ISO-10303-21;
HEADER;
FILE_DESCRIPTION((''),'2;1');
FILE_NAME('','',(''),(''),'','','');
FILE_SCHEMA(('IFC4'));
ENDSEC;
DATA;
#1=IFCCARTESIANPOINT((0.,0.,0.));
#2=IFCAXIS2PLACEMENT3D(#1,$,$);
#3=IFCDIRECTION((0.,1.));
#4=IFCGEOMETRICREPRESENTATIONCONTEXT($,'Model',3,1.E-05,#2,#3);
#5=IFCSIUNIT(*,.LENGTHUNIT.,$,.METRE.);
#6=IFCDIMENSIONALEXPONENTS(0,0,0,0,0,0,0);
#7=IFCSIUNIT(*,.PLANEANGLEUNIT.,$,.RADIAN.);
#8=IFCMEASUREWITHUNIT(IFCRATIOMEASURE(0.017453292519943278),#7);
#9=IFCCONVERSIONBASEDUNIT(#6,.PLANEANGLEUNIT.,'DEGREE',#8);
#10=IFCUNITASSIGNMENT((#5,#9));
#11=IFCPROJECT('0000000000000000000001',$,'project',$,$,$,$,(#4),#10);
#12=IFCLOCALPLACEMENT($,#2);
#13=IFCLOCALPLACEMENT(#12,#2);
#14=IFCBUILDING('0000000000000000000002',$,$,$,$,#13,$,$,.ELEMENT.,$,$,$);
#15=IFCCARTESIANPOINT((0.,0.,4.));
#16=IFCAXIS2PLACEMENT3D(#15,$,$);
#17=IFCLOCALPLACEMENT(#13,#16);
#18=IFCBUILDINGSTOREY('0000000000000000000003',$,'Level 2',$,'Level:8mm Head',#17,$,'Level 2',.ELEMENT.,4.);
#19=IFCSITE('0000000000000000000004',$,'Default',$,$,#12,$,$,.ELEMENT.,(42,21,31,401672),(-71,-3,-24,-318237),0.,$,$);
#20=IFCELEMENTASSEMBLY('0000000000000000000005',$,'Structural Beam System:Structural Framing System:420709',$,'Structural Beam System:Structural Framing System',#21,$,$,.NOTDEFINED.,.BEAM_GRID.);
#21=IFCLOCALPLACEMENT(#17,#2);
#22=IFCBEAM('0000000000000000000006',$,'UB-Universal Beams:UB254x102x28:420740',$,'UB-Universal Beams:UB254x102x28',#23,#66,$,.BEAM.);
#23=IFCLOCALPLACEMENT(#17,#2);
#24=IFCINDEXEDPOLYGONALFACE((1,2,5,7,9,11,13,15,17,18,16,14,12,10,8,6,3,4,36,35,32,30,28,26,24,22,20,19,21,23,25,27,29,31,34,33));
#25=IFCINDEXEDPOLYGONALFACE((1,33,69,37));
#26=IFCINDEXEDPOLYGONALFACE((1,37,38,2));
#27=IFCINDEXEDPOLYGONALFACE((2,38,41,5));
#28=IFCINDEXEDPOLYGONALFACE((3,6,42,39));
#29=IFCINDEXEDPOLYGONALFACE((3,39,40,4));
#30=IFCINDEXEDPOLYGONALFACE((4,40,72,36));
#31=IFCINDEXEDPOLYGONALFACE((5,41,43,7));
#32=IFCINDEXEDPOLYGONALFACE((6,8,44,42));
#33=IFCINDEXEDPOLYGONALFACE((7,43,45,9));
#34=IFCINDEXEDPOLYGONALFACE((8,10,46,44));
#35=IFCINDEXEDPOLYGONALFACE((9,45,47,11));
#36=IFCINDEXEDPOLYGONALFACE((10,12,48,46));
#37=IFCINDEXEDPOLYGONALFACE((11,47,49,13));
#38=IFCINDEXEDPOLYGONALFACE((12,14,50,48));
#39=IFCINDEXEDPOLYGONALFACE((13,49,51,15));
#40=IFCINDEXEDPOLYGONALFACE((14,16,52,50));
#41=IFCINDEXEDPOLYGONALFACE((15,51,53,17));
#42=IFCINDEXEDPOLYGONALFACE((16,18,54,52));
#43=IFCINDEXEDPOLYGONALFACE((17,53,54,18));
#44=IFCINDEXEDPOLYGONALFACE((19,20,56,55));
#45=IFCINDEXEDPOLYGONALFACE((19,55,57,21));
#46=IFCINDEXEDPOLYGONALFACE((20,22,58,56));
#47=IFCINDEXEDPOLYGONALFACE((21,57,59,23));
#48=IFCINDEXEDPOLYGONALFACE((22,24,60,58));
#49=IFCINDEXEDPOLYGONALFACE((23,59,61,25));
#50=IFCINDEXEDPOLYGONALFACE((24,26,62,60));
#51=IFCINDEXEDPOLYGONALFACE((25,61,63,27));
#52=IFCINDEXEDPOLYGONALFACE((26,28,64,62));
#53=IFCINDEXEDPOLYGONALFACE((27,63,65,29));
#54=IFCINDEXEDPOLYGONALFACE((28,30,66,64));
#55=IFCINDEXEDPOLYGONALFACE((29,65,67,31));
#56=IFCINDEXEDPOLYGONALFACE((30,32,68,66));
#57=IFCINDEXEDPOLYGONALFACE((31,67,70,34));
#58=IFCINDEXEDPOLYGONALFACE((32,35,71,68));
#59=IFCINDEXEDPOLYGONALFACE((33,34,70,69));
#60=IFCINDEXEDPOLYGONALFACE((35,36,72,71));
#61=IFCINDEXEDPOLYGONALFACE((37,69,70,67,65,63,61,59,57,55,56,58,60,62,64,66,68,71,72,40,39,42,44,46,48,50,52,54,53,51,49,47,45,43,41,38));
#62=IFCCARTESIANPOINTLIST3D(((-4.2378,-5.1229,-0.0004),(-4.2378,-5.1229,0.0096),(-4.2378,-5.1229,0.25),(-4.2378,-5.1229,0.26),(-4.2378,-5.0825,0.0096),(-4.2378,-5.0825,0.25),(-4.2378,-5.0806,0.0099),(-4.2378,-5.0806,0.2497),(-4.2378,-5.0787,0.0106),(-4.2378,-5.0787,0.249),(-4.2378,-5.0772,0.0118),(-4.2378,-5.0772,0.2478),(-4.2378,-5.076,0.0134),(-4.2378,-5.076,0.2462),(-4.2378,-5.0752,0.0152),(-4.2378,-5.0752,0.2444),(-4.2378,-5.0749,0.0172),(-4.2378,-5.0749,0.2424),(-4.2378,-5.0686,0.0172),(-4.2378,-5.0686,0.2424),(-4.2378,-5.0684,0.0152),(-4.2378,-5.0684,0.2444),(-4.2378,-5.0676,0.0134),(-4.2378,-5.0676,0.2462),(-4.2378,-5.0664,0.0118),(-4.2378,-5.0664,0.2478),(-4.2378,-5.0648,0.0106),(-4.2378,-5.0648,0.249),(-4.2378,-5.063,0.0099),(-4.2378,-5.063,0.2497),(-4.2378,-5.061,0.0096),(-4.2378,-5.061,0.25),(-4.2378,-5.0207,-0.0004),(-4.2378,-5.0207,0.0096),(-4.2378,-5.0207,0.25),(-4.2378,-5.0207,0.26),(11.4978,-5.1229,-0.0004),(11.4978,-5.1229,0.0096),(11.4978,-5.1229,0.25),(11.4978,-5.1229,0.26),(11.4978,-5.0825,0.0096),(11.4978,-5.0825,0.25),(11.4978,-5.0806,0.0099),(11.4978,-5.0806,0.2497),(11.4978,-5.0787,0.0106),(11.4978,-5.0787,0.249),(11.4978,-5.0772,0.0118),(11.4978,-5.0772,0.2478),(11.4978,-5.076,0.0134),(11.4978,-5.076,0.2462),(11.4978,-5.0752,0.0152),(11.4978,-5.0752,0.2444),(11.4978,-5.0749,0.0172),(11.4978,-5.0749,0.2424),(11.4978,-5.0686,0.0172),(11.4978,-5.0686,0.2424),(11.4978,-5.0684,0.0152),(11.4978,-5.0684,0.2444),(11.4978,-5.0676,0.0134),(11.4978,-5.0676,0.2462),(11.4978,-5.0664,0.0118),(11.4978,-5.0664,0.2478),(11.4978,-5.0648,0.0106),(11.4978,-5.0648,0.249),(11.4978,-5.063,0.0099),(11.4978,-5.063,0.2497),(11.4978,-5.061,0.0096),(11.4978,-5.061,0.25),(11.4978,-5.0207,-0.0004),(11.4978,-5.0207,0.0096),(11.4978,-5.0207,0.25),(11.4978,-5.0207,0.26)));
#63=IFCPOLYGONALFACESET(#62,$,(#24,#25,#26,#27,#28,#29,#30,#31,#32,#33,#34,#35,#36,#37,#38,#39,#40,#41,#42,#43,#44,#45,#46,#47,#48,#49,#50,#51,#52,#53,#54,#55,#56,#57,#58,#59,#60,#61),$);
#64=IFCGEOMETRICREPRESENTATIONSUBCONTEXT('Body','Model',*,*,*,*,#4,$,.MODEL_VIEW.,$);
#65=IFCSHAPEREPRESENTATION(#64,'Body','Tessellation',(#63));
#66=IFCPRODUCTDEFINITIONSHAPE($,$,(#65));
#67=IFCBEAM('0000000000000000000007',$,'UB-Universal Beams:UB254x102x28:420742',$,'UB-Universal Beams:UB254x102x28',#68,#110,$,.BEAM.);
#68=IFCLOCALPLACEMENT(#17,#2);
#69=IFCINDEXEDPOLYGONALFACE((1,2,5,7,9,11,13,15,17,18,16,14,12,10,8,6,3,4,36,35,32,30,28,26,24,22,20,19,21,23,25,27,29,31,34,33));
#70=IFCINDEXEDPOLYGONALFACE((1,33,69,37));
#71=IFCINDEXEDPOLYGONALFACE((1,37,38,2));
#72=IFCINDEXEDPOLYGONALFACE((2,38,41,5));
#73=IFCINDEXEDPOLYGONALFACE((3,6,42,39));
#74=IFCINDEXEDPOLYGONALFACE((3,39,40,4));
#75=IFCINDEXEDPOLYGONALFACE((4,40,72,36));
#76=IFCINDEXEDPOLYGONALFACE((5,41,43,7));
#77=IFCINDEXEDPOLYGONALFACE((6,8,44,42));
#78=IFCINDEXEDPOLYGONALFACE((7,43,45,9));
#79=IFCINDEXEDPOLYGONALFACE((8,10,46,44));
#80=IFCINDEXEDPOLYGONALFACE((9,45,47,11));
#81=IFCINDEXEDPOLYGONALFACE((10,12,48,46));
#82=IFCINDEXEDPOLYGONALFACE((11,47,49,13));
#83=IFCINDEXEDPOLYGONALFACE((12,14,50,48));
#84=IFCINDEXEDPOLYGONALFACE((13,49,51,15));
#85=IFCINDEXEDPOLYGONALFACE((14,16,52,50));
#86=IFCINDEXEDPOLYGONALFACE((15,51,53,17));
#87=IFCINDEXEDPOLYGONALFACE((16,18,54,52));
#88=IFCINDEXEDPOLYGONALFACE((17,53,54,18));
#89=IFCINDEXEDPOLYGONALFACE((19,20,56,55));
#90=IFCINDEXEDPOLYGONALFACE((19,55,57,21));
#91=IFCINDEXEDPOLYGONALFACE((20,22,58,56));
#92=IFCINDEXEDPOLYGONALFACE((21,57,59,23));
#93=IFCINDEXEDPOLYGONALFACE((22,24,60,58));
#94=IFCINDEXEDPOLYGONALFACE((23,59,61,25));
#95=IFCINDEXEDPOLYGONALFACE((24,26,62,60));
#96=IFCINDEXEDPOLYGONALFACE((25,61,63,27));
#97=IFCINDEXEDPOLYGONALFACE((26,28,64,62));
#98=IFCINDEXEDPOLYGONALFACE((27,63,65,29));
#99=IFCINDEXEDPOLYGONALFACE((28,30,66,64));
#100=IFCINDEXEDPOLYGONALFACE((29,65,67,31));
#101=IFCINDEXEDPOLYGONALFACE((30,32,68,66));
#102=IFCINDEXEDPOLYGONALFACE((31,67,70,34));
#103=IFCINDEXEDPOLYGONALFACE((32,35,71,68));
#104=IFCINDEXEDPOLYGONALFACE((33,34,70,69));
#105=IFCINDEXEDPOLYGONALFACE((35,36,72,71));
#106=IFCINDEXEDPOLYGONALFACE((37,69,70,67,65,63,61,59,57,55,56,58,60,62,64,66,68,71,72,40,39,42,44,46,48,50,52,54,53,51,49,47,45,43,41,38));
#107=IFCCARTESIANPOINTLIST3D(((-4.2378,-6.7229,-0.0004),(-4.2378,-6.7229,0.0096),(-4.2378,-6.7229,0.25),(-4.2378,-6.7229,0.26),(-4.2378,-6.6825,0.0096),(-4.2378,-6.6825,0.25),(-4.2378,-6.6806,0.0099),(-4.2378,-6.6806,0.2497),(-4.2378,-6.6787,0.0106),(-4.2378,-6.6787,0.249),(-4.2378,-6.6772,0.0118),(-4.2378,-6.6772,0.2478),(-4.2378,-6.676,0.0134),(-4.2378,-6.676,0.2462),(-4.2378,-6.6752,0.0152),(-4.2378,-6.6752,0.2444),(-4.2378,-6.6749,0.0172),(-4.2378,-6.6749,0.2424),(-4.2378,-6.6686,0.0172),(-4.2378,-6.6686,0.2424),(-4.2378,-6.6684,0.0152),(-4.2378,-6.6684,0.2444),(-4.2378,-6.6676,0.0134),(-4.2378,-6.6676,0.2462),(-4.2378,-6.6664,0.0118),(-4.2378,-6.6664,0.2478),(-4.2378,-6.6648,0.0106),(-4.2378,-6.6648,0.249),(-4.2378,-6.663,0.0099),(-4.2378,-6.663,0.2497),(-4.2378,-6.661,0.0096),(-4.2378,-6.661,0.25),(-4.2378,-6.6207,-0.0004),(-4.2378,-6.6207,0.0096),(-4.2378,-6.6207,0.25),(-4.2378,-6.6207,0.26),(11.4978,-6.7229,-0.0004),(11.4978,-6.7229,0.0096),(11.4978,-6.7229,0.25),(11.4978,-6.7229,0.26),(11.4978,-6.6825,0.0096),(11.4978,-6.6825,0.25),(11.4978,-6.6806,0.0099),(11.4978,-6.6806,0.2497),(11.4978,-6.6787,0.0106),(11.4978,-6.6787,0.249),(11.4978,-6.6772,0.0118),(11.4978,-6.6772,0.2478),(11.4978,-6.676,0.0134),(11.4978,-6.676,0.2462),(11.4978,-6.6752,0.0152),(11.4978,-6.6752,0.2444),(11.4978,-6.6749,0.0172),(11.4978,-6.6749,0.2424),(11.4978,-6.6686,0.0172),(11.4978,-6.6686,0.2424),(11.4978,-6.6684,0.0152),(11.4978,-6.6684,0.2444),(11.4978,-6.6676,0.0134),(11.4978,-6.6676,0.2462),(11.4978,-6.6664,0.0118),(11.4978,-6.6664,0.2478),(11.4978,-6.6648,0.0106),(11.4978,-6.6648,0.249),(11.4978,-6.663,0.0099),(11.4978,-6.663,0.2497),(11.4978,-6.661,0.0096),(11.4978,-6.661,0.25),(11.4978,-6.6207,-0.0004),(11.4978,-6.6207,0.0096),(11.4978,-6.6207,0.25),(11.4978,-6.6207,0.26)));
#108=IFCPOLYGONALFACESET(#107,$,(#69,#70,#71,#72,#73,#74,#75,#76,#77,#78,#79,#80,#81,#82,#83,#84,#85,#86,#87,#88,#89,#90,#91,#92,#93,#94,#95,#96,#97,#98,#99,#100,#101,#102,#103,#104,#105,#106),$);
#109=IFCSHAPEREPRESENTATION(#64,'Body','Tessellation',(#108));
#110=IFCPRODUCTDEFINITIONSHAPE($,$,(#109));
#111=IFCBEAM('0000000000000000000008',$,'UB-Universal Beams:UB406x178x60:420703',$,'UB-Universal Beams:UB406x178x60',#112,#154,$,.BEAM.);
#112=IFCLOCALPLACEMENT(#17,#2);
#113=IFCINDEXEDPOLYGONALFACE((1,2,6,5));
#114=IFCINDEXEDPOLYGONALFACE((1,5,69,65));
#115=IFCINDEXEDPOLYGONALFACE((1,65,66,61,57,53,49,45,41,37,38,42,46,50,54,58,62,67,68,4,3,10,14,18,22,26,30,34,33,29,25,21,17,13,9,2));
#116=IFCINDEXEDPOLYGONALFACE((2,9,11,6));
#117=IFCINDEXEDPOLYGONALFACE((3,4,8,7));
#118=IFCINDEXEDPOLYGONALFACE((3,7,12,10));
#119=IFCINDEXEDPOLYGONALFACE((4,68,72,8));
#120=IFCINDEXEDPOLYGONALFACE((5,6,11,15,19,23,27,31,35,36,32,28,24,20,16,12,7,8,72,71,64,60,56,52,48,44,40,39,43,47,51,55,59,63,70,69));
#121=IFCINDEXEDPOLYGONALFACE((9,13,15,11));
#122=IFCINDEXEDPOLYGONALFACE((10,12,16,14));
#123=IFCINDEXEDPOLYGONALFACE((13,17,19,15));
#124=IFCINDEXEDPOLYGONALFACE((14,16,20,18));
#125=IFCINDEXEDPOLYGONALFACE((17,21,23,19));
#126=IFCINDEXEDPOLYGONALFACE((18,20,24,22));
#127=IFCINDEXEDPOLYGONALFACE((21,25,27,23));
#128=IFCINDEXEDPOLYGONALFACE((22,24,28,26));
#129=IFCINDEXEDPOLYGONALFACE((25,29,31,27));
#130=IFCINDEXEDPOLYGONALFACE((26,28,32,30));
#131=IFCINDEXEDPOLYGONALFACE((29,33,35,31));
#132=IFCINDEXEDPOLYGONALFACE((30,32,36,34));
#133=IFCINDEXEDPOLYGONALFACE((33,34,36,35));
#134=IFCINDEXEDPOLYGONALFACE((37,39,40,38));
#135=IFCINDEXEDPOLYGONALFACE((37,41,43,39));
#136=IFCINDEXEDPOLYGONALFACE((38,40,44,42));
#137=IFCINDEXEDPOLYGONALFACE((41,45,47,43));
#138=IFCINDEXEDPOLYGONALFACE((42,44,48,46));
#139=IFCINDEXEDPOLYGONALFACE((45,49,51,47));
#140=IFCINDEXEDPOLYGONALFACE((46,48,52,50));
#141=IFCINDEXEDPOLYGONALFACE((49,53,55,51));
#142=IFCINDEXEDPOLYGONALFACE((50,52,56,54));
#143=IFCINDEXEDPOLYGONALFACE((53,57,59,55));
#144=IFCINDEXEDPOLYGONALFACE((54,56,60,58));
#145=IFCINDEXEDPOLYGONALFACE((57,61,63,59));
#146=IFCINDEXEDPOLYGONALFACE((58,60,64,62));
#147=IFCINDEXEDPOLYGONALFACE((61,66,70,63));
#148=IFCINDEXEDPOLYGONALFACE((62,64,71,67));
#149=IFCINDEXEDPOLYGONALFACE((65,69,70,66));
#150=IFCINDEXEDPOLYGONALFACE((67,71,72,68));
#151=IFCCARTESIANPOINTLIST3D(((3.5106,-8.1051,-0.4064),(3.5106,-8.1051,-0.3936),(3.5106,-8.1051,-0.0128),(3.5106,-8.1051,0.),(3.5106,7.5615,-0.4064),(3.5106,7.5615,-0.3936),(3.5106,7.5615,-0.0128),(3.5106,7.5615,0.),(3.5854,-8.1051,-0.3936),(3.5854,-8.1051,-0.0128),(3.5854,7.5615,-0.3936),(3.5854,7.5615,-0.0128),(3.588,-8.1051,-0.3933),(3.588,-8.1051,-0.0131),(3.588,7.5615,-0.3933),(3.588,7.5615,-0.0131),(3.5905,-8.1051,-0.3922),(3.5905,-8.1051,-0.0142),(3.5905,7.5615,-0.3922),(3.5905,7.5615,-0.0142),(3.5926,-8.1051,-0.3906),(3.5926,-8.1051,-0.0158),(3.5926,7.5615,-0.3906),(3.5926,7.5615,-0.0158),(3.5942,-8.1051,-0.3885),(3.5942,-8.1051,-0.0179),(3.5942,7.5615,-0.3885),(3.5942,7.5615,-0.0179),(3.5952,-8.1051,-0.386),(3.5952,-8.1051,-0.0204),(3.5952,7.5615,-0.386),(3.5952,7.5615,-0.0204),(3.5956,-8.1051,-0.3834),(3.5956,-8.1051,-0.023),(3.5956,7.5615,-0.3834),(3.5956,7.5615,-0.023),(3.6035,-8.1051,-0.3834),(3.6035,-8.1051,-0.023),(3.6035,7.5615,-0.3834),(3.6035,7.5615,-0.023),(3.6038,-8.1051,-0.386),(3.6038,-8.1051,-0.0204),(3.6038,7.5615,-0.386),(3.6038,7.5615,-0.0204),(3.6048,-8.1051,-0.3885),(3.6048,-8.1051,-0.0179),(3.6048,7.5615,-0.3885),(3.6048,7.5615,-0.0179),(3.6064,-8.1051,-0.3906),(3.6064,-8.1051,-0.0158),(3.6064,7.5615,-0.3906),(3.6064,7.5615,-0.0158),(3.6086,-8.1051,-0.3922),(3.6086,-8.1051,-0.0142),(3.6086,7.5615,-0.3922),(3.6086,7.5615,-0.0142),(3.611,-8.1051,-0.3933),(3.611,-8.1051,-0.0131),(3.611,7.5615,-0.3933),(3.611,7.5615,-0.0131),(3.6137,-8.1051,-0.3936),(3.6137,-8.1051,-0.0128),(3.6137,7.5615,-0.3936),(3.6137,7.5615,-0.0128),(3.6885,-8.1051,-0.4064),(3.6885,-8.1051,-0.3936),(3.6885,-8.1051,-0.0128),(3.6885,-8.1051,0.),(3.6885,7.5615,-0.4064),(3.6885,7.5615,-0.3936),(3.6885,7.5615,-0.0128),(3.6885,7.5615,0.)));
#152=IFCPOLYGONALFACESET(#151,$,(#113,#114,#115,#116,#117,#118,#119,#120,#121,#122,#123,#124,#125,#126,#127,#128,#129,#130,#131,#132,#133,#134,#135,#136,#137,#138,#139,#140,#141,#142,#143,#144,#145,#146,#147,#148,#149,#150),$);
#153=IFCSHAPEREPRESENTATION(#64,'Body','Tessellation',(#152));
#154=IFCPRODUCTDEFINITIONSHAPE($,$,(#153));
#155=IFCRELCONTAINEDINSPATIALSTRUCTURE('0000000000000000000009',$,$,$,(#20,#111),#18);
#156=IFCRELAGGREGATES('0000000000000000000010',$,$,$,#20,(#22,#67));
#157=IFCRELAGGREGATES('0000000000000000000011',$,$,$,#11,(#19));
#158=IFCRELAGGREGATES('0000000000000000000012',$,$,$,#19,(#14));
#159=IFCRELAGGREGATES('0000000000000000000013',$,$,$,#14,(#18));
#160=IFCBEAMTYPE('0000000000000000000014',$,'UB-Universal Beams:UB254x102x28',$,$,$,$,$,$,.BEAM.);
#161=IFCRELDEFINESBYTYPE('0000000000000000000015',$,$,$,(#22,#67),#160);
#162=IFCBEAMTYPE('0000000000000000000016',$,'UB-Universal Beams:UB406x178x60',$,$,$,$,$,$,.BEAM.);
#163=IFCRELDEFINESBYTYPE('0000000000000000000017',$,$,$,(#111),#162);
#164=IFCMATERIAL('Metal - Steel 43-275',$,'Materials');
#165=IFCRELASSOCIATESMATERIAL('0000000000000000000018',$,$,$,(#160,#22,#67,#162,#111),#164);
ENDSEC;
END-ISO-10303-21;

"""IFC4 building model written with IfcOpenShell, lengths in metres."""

from ifc_helpers import new_model, entity, si_unit, converted_unit, direction, frame, origin, place, context, subcontext, project, spatial, line, arc, indexed_curve, outline, extrude, source, transform, mapped, material, type_object, type_shapes, element, aggregate, save


model = new_model("IFC4")

# Units and contexts
model_context = context("Model", 3, precision=1e-05, world=origin(), true_north=direction((0.0, 1.0)))
body_context = subcontext(model_context, "Body", "Model", "MODEL_VIEW")
ifc_project = project(units=[si_unit("LENGTHUNIT", "METRE"), converted_unit("PLANEANGLEUNIT", "DEGREE", entity("IfcRatioMeasure", 0.017453292519943278), si_unit("PLANEANGLEUNIT", "RADIAN"), dimensions=[0, 0, 0, 0, 0, 0, 0])], contexts=[model_context])

# Site, building, storey
site_placement = place(None, origin())
site = spatial("IfcSite", under=ifc_project, at=site_placement, Name="Default", CompositionType="ELEMENT", RefLatitude=(42, 21, 31, 401672), RefLongitude=(-71, -3, -24, -318237), RefElevation=0.0)
building_placement = place(site_placement, origin())
building = spatial("IfcBuilding", under=site, at=building_placement, CompositionType="ELEMENT")
storey_placement = place(building_placement, frame((0.0, 0.0, 4.0)))
storey = spatial("IfcBuildingStorey", under=building, at=storey_placement, Name="Level 2", ObjectType="Level:8mm Head", LongName="Level 2", CompositionType="ELEMENT", Elevation=4.0)

# Shared definitions
ifc_material_1 = material(Name="Metal - Steel 43-275", Category="Materials")

# Element assembly, beams
assembly_placement = place(storey_placement, origin())
assembly = element("IfcElementAssembly", 1, at=assembly_placement, inside=storey, Name="Structural Beam System:Structural Framing System:420709", ObjectType="Structural Beam System:Structural Framing System", AssemblyPlace="NOTDEFINED", PredefinedType="BEAM_GRID")
beam_type_1 = type_object("IfcBeamType", Name="UB-Universal Beams:UB254x102x28", PredefinedType="BEAM", material=ifc_material_1)
shared_shape_1 = source(origin(), body_context, "Body", "SweptSolid", [
    extrude(outline(indexed_curve([(-0.1302, -0.0511), (-0.1202, -0.0511), (-0.1202, -0.0107), (-0.118, -0.0054), (-0.1126, -0.0031), (0.1126, -0.0031), (0.118, -0.0054), (0.1202, -0.0107), (0.1202, -0.0511), (0.1302, -0.0511), (0.1302, 0.0511), (0.1202, 0.0511), (0.1202, 0.0108), (0.118, 0.0054), (0.1126, 0.0032), (-0.1126, 0.0032), (-0.118, 0.0054), (-0.1202, 0.0108), (-0.1202, 0.0511), (-0.1302, 0.0511)], segments=[line(1, 2, 3), arc(3, 4, 5), line(5, 6), arc(6, 7, 8), line(8, 9, 10, 11, 12, 13), arc(13, 14, 15), line(15, 16), arc(16, 17, 18), line(18, 19, 20, 1)], self_intersect=False)), frame((-7.8373, 0.0, 0.0), z_axis=(1.0, 0.0, 0.0), x_axis=(0.0, 0.0, -1.0)), (0.0, 0.0, 1.0), 15.7356),
])
type_shapes(beam_type_1, [shared_shape_1])
beam_1_placement = place(assembly_placement, frame((3.5995, -5.0718, 0.1298)))
beam_1 = element("IfcBeam", 2, at=beam_1_placement, type_object=beam_type_1, material=ifc_material_1, Name="UB-Universal Beams:UB254x102x28:420740", ObjectType="UB-Universal Beams:UB254x102x28", PredefinedType="BEAM", context=body_context, shape_type="MappedRepresentation", body=[
    mapped(shared_shape_1, transform((0.0, 0.0, 0.0), scale=1.0)),
])
beam_2_placement = place(assembly_placement, frame((3.5995, -6.6718, 0.1298)))
beam_2 = element("IfcBeam", 3, at=beam_2_placement, type_object=beam_type_1, material=ifc_material_1, Name="UB-Universal Beams:UB254x102x28:420742", ObjectType="UB-Universal Beams:UB254x102x28", PredefinedType="BEAM", context=body_context, shape_type="MappedRepresentation", body=[
    mapped(shared_shape_1, transform((0.0, 0.0, 0.0), scale=1.0)),
])
aggregate(assembly, [beam_1, beam_2])

# Beam
beam_type_2 = type_object("IfcBeamType", Name="UB-Universal Beams:UB406x178x60", PredefinedType="BEAM", material=ifc_material_1)
shared_shape_2 = source(origin(), body_context, "Body", "SweptSolid", [
    extrude(outline(indexed_curve([(-0.089, -0.2032), (0.0889, -0.2032), (0.0889, -0.1904), (0.0141, -0.1904), (0.0069, -0.1874), (0.0039, -0.1802), (0.0039, 0.1802), (0.0069, 0.1874), (0.0141, 0.1904), (0.0889, 0.1904), (0.0889, 0.2032), (-0.089, 0.2032), (-0.089, 0.1904), (-0.0142, 0.1904), (-0.0069, 0.1874), (-0.004, 0.1802), (-0.004, -0.1802), (-0.0069, -0.1874), (-0.0142, -0.1904), (-0.089, -0.1904)], segments=[line(1, 2, 3, 4), arc(4, 5, 6), line(6, 7), arc(7, 8, 9), line(9, 10, 11, 12, 13, 14), arc(14, 15, 16), line(16, 17), arc(17, 18, 19), line(19, 20, 1)], self_intersect=False)), frame((3.5995, -8.1051, 3.7968), z_axis=(0.0, 1.0, 0.0), x_axis=(-1.0, 0.0, 0.0)), (0.0, 0.0, 1.0), 15.6666),
])
type_shapes(beam_type_2, [shared_shape_2])
beam_3_placement = place(storey_placement, frame((0.0, 0.0, -4.0)))
element("IfcBeam", 4, at=beam_3_placement, inside=storey, type_object=beam_type_2, material=ifc_material_1, Name="UB-Universal Beams:UB406x178x60:420703", ObjectType="UB-Universal Beams:UB406x178x60", PredefinedType="BEAM", context=body_context, shape_type="MappedRepresentation", body=[
    mapped(shared_shape_2, transform((0.0, 0.0, 0.0), scale=1.0)),
])

save(model, "model.ifc")
